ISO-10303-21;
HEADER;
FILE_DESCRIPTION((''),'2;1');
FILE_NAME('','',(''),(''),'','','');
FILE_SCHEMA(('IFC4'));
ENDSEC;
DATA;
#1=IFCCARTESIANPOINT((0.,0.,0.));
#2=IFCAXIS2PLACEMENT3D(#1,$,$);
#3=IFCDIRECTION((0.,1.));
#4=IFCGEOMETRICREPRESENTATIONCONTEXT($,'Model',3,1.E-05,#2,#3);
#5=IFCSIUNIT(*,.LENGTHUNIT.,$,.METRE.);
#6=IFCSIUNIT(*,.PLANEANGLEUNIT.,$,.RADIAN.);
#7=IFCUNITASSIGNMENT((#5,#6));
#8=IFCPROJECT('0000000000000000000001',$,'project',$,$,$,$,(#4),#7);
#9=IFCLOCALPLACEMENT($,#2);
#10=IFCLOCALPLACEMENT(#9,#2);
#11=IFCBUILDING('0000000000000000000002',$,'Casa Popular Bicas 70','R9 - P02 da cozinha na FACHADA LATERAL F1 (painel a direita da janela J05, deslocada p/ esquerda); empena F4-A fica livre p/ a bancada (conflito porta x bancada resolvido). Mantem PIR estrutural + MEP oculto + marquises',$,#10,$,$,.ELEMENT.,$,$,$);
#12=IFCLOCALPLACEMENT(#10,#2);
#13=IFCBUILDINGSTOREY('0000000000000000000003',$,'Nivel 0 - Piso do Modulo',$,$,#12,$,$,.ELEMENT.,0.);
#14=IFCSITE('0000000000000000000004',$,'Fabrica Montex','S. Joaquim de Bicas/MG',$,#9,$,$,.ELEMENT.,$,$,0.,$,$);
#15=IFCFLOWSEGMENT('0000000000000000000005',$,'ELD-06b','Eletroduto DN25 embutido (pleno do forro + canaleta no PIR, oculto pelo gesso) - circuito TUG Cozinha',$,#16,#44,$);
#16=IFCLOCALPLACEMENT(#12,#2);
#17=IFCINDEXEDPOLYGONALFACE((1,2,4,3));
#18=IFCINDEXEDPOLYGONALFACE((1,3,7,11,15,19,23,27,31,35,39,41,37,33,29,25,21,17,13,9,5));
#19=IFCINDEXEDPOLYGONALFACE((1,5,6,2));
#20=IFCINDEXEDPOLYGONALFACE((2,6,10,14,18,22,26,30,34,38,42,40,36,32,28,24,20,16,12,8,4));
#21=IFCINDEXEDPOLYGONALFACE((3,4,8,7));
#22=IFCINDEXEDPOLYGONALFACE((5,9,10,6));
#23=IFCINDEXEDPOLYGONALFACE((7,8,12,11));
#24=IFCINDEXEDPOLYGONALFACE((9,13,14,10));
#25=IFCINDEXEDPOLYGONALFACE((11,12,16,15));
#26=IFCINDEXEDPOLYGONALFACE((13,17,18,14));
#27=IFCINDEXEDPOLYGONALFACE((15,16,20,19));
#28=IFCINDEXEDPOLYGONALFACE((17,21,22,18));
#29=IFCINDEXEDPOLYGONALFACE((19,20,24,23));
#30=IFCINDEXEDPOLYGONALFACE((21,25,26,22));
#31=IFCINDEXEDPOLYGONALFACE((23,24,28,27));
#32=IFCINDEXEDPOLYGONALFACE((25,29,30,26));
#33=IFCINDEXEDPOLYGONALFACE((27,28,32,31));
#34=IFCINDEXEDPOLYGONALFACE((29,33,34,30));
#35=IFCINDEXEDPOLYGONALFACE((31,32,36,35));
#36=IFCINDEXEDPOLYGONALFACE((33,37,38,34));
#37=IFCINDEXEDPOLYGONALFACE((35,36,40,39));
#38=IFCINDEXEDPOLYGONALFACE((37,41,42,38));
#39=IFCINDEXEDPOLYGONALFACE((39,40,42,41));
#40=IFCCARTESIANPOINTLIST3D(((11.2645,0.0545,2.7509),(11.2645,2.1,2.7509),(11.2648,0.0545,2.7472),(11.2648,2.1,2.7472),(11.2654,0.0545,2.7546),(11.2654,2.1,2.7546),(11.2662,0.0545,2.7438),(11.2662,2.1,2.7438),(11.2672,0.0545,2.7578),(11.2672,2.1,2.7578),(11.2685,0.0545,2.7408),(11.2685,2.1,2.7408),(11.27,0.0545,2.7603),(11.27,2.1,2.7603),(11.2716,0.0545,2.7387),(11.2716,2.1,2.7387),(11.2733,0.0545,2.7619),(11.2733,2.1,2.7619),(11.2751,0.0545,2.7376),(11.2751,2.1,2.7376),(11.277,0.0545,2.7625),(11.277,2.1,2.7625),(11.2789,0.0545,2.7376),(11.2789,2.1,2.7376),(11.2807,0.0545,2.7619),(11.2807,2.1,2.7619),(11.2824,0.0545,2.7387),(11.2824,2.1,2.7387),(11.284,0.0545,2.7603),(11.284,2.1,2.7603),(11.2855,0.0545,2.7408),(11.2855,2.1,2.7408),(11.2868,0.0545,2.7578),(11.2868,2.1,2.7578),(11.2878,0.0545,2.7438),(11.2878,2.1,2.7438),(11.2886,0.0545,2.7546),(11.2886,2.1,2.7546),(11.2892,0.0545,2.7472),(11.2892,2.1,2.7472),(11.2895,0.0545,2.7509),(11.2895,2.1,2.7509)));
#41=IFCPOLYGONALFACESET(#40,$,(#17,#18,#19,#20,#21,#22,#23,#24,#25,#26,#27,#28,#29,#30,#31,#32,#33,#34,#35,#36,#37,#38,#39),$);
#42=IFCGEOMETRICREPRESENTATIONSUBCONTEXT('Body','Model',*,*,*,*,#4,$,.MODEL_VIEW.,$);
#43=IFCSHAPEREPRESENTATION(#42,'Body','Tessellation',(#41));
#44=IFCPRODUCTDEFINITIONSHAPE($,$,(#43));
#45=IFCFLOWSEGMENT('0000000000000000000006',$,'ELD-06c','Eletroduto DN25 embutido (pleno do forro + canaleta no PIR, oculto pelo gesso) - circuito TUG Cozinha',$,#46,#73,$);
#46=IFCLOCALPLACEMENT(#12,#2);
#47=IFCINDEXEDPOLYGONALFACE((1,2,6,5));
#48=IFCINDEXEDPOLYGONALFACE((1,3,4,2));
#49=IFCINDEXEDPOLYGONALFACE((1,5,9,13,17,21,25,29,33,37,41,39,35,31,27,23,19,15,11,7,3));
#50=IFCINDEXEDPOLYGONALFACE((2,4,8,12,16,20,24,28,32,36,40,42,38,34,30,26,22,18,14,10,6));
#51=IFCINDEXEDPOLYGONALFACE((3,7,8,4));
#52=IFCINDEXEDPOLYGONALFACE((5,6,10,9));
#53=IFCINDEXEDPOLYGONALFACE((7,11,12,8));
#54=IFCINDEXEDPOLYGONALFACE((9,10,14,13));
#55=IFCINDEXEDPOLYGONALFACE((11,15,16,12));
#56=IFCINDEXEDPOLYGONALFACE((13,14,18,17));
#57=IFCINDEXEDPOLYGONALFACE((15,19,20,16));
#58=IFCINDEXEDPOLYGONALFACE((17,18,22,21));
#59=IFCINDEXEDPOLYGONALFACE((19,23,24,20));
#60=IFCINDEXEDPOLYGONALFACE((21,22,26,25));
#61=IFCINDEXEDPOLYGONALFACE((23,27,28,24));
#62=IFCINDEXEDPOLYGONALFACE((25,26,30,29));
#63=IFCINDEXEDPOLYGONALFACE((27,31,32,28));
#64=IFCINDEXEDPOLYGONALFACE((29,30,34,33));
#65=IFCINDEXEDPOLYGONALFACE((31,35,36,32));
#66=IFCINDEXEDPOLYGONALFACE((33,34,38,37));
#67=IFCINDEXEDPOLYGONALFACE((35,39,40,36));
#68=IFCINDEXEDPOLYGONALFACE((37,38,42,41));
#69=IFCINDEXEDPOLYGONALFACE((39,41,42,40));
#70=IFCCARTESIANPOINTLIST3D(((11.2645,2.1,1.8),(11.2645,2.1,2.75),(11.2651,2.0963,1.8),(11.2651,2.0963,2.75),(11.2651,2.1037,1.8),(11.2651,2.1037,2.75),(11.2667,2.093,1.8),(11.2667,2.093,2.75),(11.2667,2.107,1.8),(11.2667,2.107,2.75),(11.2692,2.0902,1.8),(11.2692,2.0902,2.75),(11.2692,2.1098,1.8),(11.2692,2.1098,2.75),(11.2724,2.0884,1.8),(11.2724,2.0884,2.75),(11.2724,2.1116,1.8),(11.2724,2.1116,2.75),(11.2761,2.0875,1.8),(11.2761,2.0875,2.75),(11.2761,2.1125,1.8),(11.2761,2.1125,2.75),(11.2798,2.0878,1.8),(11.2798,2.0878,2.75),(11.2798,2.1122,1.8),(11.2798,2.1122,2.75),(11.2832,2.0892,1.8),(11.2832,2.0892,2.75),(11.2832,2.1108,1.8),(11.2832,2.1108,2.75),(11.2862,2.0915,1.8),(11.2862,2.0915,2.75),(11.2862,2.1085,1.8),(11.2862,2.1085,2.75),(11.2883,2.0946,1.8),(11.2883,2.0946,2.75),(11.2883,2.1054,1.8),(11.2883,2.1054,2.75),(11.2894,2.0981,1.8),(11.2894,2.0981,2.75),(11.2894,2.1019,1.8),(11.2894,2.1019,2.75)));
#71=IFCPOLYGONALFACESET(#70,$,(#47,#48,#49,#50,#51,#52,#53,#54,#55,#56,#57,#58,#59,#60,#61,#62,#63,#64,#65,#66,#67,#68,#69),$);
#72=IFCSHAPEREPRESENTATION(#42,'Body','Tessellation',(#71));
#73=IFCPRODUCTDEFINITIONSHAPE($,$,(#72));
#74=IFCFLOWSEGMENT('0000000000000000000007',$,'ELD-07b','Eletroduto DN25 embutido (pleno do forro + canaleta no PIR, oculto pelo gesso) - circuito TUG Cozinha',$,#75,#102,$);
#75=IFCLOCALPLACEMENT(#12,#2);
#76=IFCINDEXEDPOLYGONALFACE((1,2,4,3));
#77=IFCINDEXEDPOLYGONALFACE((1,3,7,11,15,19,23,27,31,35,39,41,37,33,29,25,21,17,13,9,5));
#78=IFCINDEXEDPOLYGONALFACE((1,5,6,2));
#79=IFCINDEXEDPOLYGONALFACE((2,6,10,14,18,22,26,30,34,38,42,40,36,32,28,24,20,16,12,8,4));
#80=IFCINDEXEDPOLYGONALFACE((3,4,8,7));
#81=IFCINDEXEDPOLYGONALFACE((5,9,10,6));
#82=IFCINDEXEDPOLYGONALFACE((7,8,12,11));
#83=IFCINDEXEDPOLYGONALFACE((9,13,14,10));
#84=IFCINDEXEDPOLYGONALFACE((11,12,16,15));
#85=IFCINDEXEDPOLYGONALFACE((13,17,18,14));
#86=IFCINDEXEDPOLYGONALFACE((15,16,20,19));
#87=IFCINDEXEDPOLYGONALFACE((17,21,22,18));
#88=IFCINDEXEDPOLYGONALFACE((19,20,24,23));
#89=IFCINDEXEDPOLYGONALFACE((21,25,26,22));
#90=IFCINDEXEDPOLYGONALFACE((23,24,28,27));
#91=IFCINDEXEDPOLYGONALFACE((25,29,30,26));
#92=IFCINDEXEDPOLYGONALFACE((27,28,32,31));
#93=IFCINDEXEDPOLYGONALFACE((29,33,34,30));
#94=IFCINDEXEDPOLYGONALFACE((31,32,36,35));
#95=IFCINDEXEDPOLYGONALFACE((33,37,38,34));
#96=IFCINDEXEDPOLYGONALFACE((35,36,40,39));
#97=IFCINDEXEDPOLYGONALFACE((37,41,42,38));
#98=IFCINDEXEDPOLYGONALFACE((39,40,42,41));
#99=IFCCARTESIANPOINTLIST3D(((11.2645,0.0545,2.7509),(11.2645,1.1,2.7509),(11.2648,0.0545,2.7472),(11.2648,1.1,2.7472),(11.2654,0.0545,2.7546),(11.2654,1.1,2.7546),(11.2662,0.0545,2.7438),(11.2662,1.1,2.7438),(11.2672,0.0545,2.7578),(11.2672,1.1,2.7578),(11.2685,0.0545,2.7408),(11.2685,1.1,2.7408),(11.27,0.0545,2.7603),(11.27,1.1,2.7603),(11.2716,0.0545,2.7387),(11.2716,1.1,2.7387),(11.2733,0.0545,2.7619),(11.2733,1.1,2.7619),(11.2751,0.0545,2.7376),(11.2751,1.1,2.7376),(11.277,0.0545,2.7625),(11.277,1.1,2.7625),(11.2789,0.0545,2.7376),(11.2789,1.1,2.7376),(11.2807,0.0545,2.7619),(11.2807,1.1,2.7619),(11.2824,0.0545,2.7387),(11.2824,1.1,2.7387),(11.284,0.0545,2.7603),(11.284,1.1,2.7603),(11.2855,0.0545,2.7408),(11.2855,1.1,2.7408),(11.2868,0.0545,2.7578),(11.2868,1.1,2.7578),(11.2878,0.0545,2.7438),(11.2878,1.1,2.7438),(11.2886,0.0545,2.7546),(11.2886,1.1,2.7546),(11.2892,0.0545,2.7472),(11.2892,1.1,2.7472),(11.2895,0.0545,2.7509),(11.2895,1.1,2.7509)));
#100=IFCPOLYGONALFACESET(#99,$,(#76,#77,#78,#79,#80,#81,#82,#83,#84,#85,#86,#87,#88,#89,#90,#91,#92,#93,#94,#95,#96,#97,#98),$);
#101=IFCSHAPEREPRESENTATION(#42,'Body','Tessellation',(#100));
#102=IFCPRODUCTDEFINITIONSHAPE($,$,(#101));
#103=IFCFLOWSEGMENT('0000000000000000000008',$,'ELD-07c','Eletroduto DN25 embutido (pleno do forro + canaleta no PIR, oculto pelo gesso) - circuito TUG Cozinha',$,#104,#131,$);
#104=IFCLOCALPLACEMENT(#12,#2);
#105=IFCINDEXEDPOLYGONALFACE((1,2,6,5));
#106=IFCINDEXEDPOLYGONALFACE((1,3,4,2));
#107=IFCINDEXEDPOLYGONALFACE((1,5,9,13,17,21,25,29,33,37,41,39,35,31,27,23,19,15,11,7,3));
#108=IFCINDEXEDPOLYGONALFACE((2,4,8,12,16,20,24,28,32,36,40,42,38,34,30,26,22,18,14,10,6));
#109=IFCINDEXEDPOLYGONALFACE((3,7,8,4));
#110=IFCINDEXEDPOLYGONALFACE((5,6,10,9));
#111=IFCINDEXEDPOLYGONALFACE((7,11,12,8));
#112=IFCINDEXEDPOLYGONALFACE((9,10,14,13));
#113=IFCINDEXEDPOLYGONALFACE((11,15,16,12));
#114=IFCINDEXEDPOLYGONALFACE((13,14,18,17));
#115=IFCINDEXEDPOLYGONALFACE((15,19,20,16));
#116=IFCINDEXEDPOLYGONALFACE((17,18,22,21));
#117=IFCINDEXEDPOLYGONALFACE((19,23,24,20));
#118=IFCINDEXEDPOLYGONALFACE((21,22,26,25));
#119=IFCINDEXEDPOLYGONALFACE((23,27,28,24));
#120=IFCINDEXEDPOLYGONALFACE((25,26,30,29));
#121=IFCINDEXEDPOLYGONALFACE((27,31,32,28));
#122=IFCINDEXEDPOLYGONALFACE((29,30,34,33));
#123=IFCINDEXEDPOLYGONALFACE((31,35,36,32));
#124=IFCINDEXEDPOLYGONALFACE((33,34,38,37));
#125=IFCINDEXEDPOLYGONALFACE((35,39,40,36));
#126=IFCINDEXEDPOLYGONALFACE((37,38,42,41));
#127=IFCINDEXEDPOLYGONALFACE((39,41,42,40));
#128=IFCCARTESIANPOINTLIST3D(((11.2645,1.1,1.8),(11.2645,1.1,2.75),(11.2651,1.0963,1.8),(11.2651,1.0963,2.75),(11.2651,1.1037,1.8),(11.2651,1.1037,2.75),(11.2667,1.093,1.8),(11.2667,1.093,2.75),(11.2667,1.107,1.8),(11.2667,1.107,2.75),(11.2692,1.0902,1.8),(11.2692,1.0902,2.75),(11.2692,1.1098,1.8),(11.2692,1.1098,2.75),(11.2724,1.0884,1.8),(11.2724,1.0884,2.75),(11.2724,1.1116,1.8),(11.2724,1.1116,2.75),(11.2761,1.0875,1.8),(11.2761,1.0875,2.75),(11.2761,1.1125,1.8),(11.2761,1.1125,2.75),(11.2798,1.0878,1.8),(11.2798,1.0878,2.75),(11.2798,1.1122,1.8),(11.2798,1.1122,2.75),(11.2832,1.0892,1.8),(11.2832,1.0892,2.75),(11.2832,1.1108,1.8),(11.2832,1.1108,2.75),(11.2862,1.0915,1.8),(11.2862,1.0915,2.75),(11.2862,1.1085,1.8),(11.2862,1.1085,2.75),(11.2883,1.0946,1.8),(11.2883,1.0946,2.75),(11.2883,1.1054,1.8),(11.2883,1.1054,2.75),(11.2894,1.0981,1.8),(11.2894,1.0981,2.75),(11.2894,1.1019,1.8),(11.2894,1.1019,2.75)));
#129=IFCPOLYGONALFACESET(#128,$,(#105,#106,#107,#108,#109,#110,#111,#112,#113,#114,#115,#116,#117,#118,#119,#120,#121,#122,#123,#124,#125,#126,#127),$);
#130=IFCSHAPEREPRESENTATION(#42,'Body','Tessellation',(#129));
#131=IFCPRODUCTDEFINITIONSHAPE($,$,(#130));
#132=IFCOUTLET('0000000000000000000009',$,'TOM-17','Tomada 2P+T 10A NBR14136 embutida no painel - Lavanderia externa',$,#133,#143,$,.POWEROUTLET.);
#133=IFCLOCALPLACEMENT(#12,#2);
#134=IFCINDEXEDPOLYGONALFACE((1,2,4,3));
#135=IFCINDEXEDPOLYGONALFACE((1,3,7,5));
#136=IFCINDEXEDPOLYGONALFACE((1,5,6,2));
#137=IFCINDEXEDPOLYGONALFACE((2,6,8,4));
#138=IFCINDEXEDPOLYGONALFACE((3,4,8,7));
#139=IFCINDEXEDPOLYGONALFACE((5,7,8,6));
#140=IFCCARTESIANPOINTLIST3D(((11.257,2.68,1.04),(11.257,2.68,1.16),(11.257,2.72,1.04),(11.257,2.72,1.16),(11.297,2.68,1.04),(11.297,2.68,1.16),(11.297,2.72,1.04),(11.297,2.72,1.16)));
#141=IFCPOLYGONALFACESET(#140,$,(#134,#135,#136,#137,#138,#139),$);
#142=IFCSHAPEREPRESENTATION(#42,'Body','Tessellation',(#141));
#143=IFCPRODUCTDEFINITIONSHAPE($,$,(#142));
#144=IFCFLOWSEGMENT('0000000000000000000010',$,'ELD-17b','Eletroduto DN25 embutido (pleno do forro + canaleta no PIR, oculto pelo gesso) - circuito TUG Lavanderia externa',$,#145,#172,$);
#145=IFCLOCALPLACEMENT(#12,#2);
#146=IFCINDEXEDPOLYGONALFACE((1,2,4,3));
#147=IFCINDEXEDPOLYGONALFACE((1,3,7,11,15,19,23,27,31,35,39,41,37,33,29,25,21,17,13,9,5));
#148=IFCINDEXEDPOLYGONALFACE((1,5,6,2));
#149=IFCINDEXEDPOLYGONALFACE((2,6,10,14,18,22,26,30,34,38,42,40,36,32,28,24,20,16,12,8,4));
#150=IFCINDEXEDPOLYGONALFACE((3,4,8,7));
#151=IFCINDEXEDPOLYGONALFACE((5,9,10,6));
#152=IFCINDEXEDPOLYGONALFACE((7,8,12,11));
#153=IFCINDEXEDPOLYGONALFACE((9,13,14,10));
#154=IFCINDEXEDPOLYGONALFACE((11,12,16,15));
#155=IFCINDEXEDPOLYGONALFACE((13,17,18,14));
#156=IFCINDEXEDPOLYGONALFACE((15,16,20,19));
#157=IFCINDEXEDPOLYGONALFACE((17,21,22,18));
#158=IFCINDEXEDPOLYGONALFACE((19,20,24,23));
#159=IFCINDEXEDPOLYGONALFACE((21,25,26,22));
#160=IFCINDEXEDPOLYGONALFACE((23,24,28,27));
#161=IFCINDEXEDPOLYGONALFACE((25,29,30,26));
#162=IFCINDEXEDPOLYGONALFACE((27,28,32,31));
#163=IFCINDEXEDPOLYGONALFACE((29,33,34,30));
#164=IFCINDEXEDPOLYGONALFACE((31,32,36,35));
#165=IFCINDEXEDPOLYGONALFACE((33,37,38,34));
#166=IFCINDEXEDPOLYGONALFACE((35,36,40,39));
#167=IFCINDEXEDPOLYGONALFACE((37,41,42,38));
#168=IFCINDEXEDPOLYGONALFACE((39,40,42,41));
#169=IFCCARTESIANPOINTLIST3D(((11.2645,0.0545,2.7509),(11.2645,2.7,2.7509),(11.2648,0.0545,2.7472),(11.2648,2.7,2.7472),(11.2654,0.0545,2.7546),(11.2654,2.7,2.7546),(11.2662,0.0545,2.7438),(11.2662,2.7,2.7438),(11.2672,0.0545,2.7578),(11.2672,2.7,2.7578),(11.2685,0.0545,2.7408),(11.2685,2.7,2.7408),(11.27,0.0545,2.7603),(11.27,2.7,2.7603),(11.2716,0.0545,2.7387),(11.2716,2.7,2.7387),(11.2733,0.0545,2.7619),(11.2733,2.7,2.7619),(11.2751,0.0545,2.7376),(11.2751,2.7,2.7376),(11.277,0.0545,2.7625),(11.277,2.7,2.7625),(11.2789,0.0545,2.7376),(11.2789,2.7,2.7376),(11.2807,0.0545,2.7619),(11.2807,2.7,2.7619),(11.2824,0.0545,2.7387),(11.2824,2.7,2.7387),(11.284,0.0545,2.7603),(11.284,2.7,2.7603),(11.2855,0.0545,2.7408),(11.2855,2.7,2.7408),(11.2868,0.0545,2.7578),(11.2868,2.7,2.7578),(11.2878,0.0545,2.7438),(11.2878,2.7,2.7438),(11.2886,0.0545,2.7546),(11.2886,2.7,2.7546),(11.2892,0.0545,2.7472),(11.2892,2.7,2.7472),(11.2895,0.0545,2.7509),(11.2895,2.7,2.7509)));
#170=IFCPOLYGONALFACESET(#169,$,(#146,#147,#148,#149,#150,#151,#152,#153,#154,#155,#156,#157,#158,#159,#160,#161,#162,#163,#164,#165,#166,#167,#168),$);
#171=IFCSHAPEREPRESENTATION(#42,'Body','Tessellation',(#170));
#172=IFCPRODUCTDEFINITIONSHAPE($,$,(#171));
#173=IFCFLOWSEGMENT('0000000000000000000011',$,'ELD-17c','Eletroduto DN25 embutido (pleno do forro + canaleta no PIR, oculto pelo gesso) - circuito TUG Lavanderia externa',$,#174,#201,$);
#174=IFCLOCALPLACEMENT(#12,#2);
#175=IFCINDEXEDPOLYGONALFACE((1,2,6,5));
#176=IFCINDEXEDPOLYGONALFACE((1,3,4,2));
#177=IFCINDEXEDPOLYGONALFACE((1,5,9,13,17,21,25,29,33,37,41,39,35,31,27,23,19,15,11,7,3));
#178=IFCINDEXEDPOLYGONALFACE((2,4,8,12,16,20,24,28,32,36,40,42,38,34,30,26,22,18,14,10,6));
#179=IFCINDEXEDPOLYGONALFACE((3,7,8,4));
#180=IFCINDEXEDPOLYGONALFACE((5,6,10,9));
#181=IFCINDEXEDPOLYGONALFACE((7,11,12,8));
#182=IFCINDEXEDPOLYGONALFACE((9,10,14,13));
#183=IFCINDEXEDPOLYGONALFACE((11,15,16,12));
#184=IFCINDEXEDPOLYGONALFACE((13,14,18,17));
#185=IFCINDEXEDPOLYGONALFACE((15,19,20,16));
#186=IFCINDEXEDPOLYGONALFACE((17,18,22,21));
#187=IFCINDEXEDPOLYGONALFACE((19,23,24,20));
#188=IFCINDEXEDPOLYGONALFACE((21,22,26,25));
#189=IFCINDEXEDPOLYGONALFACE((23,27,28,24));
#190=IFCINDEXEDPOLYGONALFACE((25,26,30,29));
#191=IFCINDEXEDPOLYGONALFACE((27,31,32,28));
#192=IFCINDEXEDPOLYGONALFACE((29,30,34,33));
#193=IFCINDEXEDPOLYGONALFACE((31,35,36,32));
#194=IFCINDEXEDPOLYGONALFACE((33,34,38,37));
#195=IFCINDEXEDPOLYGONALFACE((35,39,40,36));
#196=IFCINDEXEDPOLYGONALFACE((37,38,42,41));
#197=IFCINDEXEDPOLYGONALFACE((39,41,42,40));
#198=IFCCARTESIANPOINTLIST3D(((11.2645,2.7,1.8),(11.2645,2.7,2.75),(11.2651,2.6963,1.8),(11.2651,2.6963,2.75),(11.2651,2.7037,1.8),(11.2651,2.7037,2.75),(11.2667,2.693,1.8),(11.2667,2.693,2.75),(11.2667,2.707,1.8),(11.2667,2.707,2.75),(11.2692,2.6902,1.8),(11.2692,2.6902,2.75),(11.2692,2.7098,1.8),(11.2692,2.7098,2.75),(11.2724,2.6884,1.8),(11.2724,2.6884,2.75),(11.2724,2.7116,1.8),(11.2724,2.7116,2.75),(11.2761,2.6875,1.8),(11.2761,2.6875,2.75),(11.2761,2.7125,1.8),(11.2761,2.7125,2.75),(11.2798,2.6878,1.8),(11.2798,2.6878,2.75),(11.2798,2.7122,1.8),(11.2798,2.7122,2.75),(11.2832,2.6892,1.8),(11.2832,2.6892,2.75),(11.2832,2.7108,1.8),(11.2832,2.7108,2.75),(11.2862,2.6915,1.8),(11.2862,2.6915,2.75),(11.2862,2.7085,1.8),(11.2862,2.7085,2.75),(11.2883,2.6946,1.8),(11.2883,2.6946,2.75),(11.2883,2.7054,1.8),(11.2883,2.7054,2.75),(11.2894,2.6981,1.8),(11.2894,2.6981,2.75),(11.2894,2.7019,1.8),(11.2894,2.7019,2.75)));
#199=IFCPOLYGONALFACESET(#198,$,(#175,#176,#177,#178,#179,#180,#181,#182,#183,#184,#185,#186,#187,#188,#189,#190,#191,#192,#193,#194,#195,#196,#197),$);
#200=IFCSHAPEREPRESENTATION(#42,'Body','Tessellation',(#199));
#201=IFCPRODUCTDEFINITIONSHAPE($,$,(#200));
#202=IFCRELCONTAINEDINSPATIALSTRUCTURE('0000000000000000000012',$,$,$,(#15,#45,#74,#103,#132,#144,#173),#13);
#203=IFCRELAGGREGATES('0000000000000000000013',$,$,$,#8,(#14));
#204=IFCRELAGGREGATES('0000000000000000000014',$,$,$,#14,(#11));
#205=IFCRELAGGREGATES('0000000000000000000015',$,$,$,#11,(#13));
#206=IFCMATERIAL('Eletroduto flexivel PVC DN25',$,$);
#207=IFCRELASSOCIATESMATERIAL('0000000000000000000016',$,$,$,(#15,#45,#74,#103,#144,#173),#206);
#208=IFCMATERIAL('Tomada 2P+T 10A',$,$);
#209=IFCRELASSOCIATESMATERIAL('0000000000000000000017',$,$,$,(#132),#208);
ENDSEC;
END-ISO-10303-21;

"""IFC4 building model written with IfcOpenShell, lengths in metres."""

from ifc_helpers import new_model, si_unit, direction, frame, frame_2d, origin, origin_2d, place, context, subcontext, project, spatial, rectangle, circle, extrude, material, element, save


model = new_model("IFC4")

# Units and contexts
model_context = context("Model", 3, precision=1e-05, world=origin(), true_north=direction((0.0, 1.0)))
body_context = subcontext(model_context, "Body", "Model", "MODEL_VIEW")
ifc_project = project(units=[si_unit("LENGTHUNIT", "METRE"), si_unit("PLANEANGLEUNIT", "RADIAN")], contexts=[model_context])

# Site, building, storey
site_placement = place(None, origin())
site = spatial("IfcSite", under=ifc_project, at=site_placement, Name="Fabrica Montex", Description="S. Joaquim de Bicas/MG", CompositionType="ELEMENT", RefElevation=0.0)
building_placement = place(site_placement, origin())
building = spatial("IfcBuilding", under=site, at=building_placement, Name="Casa Popular Bicas 70", Description="R9 - P02 da cozinha na FACHADA LATERAL F1 (painel a direita da janela J05, deslocada p/ esquerda); empena F4-A fica livre p/ a bancada (conflito porta x bancada resolvido). Mantem PIR estrutural + MEP oculto + marquises", CompositionType="ELEMENT")
storey_placement = place(building_placement, origin())
storey = spatial("IfcBuildingStorey", under=building, at=storey_placement, Name="Nivel 0 - Piso do Modulo", CompositionType="ELEMENT", Elevation=0.0)

# Shared definitions
ifc_material_1 = material(Name="Eletroduto flexivel PVC DN25")

# Shared definitions
ifc_material_2 = material(Name="Tomada 2P+T 10A")

# Flow segments
flow_segment_1_placement = place(None, frame((11.277, 0.0545, 2.75), z_axis=(0.0, 1.0, 0.0), x_axis=(0.0, 0.0, 1.0)))
element("IfcFlowSegment", 1, at=flow_segment_1_placement, inside=storey, material=ifc_material_1, Name="ELD-06b", Description="Eletroduto DN25 embutido (pleno do forro + canaleta no PIR, oculto pelo gesso) - circuito TUG Cozinha", context=body_context, shape_type="SweptSolid", body=[
    extrude(circle(Radius=0.0125, at=origin_2d()), origin(), (0.0, 0.0, 1.0), 2.0455),
])
flow_segment_2_placement = place(None, frame((11.277, 2.1, 2.75), z_axis=(0.0, 0.0, -1.0), x_axis=(-1.0, 0.0, 0.0)))
element("IfcFlowSegment", 2, at=flow_segment_2_placement, inside=storey, material=ifc_material_1, Name="ELD-06c", Description="Eletroduto DN25 embutido (pleno do forro + canaleta no PIR, oculto pelo gesso) - circuito TUG Cozinha", context=body_context, shape_type="SweptSolid", body=[
    extrude(circle(Radius=0.0125, at=origin_2d()), origin(), (0.0, 0.0, 1.0), 0.95),
])
flow_segment_3_placement = place(None, frame((11.277, 0.0545, 2.75), z_axis=(0.0, 1.0, 0.0), x_axis=(0.0, 0.0, 1.0)))
element("IfcFlowSegment", 3, at=flow_segment_3_placement, inside=storey, material=ifc_material_1, Name="ELD-07b", Description="Eletroduto DN25 embutido (pleno do forro + canaleta no PIR, oculto pelo gesso) - circuito TUG Cozinha", context=body_context, shape_type="SweptSolid", body=[
    extrude(circle(Radius=0.0125, at=origin_2d()), origin(), (0.0, 0.0, 1.0), 1.0455),
])
flow_segment_4_placement = place(None, frame((11.277, 1.1, 2.75), z_axis=(0.0, 0.0, -1.0), x_axis=(-1.0, 0.0, 0.0)))
element("IfcFlowSegment", 4, at=flow_segment_4_placement, inside=storey, material=ifc_material_1, Name="ELD-07c", Description="Eletroduto DN25 embutido (pleno do forro + canaleta no PIR, oculto pelo gesso) - circuito TUG Cozinha", context=body_context, shape_type="SweptSolid", body=[
    extrude(circle(Radius=0.0125, at=origin_2d()), origin(), (0.0, 0.0, 1.0), 0.95),
])

# Outlet
outlet_1_placement = place(None, frame((11.297, 2.72, 1.04), z_axis=(0.0, 0.0, 1.0), x_axis=(-1.0, 0.0, 0.0)))
element("IfcOutlet", 5, at=outlet_1_placement, inside=storey, material=ifc_material_2, Name="TOM-17", Description="Tomada 2P+T 10A NBR14136 embutida no painel - Lavanderia externa", PredefinedType="POWEROUTLET", context=body_context, shape_type="SweptSolid", body=[
    extrude(rectangle(XDim=0.04, YDim=0.04, at=frame_2d((0.02, 0.02))), origin(), (0.0, 0.0, 1.0), 0.12),
])

# Flow segments
flow_segment_5_placement = place(None, frame((11.277, 0.0545, 2.75), z_axis=(0.0, 1.0, 0.0), x_axis=(0.0, 0.0, 1.0)))
element("IfcFlowSegment", 6, at=flow_segment_5_placement, inside=storey, material=ifc_material_1, Name="ELD-17b", Description="Eletroduto DN25 embutido (pleno do forro + canaleta no PIR, oculto pelo gesso) - circuito TUG Lavanderia externa", context=body_context, shape_type="SweptSolid", body=[
    extrude(circle(Radius=0.0125, at=origin_2d()), origin(), (0.0, 0.0, 1.0), 2.6455),
])
flow_segment_6_placement = place(None, frame((11.277, 2.7, 2.75), z_axis=(0.0, 0.0, -1.0), x_axis=(-1.0, 0.0, 0.0)))
element("IfcFlowSegment", 7, at=flow_segment_6_placement, inside=storey, material=ifc_material_1, Name="ELD-17c", Description="Eletroduto DN25 embutido (pleno do forro + canaleta no PIR, oculto pelo gesso) - circuito TUG Lavanderia externa", context=body_context, shape_type="SweptSolid", body=[
    extrude(circle(Radius=0.0125, at=origin_2d()), origin(), (0.0, 0.0, 1.0), 0.95),
])

save(model, "model.ifc")
